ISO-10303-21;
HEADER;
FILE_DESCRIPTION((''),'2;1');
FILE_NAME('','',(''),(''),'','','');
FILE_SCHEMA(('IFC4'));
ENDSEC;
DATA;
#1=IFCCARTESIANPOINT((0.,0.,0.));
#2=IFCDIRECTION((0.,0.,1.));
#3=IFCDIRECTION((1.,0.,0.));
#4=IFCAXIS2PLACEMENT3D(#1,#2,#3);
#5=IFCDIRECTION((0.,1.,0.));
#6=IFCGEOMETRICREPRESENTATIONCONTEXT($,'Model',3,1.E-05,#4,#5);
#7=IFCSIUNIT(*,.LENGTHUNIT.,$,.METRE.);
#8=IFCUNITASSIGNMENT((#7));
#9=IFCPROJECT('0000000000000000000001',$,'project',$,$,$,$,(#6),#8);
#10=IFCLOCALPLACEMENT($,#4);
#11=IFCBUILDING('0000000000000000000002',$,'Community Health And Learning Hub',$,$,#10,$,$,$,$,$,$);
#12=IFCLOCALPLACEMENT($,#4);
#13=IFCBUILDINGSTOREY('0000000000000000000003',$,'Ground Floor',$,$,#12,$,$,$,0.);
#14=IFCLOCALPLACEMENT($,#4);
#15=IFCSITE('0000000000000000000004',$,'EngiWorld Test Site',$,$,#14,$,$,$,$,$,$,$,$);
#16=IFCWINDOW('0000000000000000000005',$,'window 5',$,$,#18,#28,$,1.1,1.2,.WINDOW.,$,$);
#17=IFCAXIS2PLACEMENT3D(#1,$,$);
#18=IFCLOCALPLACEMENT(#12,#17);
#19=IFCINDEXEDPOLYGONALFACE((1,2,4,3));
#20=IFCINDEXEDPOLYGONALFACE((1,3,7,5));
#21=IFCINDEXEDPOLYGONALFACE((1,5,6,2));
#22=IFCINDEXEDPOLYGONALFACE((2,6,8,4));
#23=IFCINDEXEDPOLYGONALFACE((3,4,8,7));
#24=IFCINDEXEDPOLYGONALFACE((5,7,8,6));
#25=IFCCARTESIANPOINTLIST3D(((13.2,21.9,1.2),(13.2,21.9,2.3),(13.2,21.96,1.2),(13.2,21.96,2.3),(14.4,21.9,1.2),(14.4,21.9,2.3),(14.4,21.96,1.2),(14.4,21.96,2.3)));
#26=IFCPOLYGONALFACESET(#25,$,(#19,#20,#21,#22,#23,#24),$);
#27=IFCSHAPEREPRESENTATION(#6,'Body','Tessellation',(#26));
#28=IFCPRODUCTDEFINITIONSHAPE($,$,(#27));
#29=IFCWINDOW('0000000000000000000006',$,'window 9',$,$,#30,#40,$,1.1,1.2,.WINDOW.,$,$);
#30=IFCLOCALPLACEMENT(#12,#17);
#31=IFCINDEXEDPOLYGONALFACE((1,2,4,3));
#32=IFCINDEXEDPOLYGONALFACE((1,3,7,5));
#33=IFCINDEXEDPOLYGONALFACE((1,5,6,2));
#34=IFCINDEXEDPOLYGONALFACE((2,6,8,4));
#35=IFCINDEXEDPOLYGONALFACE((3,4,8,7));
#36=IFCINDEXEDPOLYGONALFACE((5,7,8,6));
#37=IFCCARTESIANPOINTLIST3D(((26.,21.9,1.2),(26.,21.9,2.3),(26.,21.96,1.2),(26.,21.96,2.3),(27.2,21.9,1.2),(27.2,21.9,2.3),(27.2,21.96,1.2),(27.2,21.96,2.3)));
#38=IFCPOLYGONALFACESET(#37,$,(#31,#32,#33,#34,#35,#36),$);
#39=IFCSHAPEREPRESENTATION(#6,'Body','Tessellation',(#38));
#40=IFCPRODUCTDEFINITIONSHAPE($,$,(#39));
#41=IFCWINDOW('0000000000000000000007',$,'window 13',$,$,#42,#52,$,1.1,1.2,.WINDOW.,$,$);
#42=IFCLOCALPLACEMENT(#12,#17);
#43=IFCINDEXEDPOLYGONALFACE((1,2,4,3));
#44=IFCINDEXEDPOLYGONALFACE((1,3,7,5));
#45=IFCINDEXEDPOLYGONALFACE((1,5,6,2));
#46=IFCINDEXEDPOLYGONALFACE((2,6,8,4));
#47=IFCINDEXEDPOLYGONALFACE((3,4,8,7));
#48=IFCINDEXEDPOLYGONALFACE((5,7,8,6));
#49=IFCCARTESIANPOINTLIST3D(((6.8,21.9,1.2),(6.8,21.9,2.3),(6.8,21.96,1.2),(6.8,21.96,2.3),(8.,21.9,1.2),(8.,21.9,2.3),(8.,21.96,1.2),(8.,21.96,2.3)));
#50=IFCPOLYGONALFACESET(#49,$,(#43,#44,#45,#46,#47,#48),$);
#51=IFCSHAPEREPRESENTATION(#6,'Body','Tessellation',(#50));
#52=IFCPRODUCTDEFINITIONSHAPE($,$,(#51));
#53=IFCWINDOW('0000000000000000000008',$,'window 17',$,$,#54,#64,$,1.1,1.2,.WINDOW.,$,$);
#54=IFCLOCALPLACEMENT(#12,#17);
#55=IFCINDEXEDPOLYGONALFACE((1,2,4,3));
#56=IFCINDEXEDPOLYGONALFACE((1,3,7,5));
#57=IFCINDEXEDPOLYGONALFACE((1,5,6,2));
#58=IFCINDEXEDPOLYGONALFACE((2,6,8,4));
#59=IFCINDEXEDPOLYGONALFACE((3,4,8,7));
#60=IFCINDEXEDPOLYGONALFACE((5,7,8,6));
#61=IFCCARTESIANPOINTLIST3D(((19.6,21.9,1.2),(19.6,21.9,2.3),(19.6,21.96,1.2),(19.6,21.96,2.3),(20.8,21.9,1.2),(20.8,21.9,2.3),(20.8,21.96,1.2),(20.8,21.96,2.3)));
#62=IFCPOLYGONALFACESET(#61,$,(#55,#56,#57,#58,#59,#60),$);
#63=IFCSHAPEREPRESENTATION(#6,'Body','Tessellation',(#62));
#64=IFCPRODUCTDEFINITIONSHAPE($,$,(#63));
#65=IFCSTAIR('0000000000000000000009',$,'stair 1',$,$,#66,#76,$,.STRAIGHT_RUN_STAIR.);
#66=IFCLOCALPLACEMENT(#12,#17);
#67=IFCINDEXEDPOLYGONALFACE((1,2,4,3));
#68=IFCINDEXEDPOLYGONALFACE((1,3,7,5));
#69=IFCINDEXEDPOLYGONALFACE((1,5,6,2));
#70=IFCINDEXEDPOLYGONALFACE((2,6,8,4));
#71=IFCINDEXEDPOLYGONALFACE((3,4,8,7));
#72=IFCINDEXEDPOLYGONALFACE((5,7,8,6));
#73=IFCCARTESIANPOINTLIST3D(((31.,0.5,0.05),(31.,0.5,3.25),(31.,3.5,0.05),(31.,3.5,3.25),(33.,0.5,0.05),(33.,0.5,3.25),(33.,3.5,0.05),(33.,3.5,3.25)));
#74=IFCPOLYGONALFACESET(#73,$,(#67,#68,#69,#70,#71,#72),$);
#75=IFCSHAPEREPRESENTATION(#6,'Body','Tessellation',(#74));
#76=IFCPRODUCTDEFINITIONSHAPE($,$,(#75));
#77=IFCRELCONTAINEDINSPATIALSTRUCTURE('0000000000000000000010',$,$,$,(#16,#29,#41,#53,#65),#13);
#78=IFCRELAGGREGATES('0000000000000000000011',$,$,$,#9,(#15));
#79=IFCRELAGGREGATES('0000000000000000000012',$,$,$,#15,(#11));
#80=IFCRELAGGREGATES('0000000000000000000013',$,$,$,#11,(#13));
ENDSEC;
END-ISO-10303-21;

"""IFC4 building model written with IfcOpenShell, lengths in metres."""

from ifc_helpers import new_model, si_unit, direction, frame, origin_with_axes, origin_2d_with_axis, place, context, project, spatial, rectangle, extrude, element, save


model = new_model("IFC4")

# Units and contexts
model_context = context("Model", 3, precision=1e-05, world=origin_with_axes(), true_north=direction((0.0, 1.0, 0.0)))
ifc_project = project(units=[si_unit("LENGTHUNIT", "METRE")], contexts=[model_context])

# Site, building, storey
site_placement = place(None, origin_with_axes())
site = spatial("IfcSite", under=ifc_project, at=site_placement, Name="EngiWorld Test Site")
building_placement = place(None, origin_with_axes())
building = spatial("IfcBuilding", under=site, at=building_placement, Name="Community Health And Learning Hub")
storey_placement = place(None, origin_with_axes())
storey = spatial("IfcBuildingStorey", under=building, at=storey_placement, Name="Ground Floor", Elevation=0.0)

# Windows
for number, where, z_axis, x_axis, name in (
    (1, (13.8, 21.93, 1.2), (0.0, 0.0, 1.0), (1.0, 0.0, 0.0), "window 5"),
    (2, (26.6, 21.93, 1.2), (0.0, 0.0, 1.0), (1.0, 0.0, 0.0), "window 9"),
    (3, (7.4, 21.93, 1.2), (0.0, 0.0, 1.0), (1.0, 0.0, 0.0), "window 13"),
    (4, (20.2, 21.93, 1.2), (0.0, 0.0, 1.0), (1.0, 0.0, 0.0), "window 17"),
):
    element("IfcWindow", number, at=place(None, frame(where, z_axis=z_axis, x_axis=x_axis)), inside=storey, Name=name, OverallHeight=1.1, OverallWidth=1.2, PredefinedType="WINDOW", context=model_context, shape_type="SweptSolid", body=[
        extrude(rectangle(XDim=1.2, YDim=0.06, at=origin_2d_with_axis()), origin_with_axes(), (0.0, 0.0, 1.0), 1.1),
    ])

# Stair
stair_placement = place(None, frame((32.0, 2.0, 0.05), z_axis=(0.0, 0.0, 1.0), x_axis=(1.0, 0.0, 0.0)))
element("IfcStair", 5, at=stair_placement, inside=storey, Name="stair 1", PredefinedType="STRAIGHT_RUN_STAIR", context=model_context, shape_type="SweptSolid", body=[
    extrude(rectangle(XDim=2.0, YDim=3.0, at=origin_2d_with_axis()), origin_with_axes(), (0.0, 0.0, 1.0), 3.2),
])

save(model, "model.ifc")
